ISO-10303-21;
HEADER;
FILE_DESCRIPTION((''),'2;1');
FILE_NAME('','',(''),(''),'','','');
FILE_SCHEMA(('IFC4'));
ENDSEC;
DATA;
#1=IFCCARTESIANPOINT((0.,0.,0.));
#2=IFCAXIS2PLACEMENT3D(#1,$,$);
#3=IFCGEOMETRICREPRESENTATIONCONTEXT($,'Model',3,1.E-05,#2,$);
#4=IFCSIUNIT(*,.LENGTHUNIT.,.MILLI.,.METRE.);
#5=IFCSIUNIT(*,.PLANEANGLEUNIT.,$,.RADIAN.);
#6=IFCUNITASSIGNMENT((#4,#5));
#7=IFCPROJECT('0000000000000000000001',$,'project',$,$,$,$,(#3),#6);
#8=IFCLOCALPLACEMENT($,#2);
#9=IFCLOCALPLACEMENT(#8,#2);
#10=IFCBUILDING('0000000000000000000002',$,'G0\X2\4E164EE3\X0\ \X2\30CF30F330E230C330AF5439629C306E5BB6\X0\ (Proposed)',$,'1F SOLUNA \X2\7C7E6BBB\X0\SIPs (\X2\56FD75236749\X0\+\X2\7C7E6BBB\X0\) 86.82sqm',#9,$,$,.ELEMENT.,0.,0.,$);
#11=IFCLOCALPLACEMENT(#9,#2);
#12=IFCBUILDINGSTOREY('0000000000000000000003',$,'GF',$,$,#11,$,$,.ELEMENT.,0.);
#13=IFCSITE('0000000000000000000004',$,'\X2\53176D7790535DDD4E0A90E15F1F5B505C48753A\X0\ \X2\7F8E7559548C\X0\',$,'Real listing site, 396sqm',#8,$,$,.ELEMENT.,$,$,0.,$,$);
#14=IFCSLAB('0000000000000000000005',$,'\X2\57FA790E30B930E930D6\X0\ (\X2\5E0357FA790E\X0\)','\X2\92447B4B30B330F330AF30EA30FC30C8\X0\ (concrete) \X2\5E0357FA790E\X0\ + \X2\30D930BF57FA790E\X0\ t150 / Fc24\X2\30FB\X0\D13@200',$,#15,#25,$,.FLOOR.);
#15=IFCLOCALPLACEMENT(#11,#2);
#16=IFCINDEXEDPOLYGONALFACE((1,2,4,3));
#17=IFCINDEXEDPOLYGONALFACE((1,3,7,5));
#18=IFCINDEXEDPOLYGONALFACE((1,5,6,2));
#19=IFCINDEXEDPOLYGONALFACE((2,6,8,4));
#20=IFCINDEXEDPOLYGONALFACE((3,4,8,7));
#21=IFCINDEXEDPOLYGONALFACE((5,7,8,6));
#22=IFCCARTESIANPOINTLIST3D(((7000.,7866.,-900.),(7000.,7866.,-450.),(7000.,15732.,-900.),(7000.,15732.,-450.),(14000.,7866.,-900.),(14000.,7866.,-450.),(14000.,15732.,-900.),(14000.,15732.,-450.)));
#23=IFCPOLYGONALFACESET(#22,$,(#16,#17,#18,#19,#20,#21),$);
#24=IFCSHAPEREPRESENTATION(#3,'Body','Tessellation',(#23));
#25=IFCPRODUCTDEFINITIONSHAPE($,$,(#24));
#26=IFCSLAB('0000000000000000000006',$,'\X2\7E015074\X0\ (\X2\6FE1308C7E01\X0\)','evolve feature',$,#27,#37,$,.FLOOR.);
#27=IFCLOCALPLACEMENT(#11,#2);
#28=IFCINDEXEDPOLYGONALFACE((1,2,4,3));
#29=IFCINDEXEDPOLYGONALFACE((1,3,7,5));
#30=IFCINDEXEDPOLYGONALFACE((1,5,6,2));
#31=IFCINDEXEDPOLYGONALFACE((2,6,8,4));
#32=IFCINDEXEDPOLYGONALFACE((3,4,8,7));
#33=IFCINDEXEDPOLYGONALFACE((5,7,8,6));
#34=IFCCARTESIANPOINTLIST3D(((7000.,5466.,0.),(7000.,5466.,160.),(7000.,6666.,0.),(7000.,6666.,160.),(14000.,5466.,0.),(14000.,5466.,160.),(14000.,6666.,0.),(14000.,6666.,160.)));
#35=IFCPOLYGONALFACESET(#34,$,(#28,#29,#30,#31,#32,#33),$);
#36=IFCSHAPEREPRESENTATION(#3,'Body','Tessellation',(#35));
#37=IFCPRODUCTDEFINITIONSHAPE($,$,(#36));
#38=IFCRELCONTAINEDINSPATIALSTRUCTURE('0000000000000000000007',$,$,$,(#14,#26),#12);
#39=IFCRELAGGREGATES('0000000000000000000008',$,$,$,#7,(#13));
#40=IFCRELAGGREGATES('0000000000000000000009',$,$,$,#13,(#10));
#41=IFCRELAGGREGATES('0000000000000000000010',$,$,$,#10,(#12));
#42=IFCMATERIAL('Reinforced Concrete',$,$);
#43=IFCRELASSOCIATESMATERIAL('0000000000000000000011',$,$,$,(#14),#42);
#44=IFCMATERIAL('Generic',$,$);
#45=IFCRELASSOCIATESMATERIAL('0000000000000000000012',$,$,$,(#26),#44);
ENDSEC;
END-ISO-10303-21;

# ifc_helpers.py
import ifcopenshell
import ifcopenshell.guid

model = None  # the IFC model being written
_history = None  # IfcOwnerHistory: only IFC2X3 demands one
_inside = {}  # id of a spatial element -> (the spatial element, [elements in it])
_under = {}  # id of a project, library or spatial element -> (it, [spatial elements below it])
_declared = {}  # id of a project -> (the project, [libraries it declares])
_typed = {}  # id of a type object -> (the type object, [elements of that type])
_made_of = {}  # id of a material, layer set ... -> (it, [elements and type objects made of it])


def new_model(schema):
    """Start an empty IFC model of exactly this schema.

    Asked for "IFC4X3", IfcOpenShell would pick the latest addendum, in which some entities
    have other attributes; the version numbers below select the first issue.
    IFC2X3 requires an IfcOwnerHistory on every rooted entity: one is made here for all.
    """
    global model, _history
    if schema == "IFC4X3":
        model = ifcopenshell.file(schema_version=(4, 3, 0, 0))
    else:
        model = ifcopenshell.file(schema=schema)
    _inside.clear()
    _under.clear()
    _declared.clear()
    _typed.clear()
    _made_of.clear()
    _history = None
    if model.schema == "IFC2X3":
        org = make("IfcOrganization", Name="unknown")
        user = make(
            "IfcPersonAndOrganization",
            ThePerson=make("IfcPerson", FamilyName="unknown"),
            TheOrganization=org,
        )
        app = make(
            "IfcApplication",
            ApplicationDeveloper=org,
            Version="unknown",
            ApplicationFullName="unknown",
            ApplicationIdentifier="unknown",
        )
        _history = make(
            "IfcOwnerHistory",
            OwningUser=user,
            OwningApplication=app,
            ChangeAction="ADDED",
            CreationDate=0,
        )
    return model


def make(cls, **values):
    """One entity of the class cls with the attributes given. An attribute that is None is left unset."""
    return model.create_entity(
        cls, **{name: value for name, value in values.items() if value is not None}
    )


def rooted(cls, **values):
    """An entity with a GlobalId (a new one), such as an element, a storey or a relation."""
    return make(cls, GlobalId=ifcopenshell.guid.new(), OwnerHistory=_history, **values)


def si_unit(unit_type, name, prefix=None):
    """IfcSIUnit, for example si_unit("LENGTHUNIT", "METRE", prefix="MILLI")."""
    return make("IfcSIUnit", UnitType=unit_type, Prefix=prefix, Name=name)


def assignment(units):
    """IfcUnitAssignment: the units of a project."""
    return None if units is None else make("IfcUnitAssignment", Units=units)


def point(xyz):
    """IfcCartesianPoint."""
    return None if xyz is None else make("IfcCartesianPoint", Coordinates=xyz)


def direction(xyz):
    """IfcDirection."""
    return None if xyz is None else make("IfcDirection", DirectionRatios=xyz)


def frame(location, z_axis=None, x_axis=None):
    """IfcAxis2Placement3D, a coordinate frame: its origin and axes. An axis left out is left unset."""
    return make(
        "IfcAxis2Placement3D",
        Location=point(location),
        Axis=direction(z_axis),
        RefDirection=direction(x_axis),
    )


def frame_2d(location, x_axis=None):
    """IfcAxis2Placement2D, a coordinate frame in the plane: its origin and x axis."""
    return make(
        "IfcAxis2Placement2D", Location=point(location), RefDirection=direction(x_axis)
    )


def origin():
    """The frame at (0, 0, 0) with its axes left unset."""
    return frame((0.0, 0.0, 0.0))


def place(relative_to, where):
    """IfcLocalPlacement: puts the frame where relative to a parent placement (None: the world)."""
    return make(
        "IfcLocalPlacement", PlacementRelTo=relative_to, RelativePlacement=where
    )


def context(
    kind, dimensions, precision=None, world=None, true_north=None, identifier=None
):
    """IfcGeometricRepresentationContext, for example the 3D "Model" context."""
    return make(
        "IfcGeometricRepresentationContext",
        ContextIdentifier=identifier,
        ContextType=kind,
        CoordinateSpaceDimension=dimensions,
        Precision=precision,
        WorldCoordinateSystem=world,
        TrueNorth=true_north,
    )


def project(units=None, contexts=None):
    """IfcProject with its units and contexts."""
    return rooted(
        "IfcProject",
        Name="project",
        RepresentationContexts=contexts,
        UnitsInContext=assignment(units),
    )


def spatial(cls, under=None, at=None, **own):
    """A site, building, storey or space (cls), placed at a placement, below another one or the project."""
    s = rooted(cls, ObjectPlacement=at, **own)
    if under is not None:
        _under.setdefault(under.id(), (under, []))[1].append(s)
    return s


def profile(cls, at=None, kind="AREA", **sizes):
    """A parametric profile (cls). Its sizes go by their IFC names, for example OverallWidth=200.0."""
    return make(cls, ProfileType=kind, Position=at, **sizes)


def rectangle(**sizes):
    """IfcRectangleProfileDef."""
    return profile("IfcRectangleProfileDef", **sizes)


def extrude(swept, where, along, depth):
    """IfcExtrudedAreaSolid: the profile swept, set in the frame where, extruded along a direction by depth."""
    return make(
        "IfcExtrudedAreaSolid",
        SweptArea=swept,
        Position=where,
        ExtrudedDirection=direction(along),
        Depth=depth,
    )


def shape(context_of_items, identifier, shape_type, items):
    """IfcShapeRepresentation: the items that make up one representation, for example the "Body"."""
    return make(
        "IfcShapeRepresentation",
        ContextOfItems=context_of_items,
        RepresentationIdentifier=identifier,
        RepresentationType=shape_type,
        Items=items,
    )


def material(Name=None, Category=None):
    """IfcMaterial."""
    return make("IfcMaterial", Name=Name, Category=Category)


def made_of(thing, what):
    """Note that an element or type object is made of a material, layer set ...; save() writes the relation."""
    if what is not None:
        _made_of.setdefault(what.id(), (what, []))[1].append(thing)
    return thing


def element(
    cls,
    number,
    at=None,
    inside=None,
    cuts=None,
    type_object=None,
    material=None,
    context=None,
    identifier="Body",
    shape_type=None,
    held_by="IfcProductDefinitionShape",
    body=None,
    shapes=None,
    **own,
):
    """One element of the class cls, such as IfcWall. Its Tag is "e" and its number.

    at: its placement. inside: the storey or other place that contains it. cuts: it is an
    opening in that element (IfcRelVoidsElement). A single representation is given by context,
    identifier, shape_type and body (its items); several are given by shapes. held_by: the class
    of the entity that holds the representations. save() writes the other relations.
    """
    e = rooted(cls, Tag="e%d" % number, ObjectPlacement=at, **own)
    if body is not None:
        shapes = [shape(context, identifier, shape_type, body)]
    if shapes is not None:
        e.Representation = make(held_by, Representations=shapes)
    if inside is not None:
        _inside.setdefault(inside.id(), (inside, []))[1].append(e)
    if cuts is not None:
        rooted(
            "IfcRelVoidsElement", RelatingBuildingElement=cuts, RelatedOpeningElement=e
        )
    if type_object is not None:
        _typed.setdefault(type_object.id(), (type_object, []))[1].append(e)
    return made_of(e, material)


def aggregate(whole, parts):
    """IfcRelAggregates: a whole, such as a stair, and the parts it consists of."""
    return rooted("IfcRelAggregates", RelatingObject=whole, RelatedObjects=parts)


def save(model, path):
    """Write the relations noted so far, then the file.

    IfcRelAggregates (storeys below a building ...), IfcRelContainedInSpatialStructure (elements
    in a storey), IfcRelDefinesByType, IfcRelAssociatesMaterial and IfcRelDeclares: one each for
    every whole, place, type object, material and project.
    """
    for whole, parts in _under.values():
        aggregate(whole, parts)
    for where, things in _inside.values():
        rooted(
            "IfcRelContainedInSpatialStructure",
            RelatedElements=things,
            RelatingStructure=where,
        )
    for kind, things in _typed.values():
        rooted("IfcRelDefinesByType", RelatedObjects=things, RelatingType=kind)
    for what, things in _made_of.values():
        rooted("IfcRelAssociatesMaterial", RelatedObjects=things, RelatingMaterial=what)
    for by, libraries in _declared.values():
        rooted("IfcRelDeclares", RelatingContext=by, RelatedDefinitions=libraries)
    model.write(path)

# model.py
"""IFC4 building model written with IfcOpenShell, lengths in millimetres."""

from ifc_helpers import new_model, si_unit, frame, frame_2d, origin, place, context, project, spatial, rectangle, extrude, material, element, save


model = new_model("IFC4")

# Units and contexts
model_context = context("Model", 3, precision=1e-05, world=origin())
ifc_project = project(units=[si_unit("LENGTHUNIT", "METRE", prefix="MILLI"), si_unit("PLANEANGLEUNIT", "RADIAN")], contexts=[model_context])

# Site, building, storey
site_placement = place(None, origin())
site = spatial("IfcSite", under=ifc_project, at=site_placement, Name="北海道川上郡弟子屈町 美留和", ObjectType="Real listing site, 396sqm", CompositionType="ELEMENT", RefElevation=0.0)
building_placement = place(site_placement, origin())
building = spatial("IfcBuilding", under=site, at=building_placement, Name="G0世代 ハンモック吹抜の家 (Proposed)", ObjectType="1F SOLUNA 籾殻SIPs (国産杉+籾殻) 86.82sqm", CompositionType="ELEMENT", ElevationOfRefHeight=0.0, ElevationOfTerrain=0.0)
storey_placement = place(building_placement, origin())
storey = spatial("IfcBuildingStorey", under=building, at=storey_placement, Name="GF", CompositionType="ELEMENT", Elevation=0.0)

# Slabs
ifc_material_1 = material(Name="Reinforced Concrete")
slab_1_placement = place(storey_placement, frame((3500.0, 3933.0, -450.0)))
element("IfcSlab", 1, at=slab_1_placement, inside=storey, material=ifc_material_1, Name="基礎スラブ (布基礎)", Description="鉄筋コンクリート (concrete) 布基礎 + ベタ基礎 t150 / Fc24・D13@200", PredefinedType="FLOOR", context=model_context, shape_type="SweptSolid", body=[
    extrude(rectangle(XDim=7000.0, YDim=7866.0, at=frame_2d((3500.0, 3933.0))), frame((3500.0, 3933.0, -450.0)), (0.0, 0.0, 1.0), 450.0),
])
ifc_material_2 = material(Name="Generic")
slab_2_placement = place(storey_placement, frame((3500.0, 2733.0, 0.0)))
element("IfcSlab", 2, at=slab_2_placement, inside=storey, material=ifc_material_2, Name="縁側 (濡れ縁)", Description="evolve feature", PredefinedType="FLOOR", context=model_context, shape_type="SweptSolid", body=[
    extrude(rectangle(XDim=7000.0, YDim=1200.0, at=frame_2d((3500.0, 600.0))), frame((3500.0, 2733.0, 0.0)), (0.0, 0.0, 1.0), 160.0),
])

save(model, "model.ifc")
